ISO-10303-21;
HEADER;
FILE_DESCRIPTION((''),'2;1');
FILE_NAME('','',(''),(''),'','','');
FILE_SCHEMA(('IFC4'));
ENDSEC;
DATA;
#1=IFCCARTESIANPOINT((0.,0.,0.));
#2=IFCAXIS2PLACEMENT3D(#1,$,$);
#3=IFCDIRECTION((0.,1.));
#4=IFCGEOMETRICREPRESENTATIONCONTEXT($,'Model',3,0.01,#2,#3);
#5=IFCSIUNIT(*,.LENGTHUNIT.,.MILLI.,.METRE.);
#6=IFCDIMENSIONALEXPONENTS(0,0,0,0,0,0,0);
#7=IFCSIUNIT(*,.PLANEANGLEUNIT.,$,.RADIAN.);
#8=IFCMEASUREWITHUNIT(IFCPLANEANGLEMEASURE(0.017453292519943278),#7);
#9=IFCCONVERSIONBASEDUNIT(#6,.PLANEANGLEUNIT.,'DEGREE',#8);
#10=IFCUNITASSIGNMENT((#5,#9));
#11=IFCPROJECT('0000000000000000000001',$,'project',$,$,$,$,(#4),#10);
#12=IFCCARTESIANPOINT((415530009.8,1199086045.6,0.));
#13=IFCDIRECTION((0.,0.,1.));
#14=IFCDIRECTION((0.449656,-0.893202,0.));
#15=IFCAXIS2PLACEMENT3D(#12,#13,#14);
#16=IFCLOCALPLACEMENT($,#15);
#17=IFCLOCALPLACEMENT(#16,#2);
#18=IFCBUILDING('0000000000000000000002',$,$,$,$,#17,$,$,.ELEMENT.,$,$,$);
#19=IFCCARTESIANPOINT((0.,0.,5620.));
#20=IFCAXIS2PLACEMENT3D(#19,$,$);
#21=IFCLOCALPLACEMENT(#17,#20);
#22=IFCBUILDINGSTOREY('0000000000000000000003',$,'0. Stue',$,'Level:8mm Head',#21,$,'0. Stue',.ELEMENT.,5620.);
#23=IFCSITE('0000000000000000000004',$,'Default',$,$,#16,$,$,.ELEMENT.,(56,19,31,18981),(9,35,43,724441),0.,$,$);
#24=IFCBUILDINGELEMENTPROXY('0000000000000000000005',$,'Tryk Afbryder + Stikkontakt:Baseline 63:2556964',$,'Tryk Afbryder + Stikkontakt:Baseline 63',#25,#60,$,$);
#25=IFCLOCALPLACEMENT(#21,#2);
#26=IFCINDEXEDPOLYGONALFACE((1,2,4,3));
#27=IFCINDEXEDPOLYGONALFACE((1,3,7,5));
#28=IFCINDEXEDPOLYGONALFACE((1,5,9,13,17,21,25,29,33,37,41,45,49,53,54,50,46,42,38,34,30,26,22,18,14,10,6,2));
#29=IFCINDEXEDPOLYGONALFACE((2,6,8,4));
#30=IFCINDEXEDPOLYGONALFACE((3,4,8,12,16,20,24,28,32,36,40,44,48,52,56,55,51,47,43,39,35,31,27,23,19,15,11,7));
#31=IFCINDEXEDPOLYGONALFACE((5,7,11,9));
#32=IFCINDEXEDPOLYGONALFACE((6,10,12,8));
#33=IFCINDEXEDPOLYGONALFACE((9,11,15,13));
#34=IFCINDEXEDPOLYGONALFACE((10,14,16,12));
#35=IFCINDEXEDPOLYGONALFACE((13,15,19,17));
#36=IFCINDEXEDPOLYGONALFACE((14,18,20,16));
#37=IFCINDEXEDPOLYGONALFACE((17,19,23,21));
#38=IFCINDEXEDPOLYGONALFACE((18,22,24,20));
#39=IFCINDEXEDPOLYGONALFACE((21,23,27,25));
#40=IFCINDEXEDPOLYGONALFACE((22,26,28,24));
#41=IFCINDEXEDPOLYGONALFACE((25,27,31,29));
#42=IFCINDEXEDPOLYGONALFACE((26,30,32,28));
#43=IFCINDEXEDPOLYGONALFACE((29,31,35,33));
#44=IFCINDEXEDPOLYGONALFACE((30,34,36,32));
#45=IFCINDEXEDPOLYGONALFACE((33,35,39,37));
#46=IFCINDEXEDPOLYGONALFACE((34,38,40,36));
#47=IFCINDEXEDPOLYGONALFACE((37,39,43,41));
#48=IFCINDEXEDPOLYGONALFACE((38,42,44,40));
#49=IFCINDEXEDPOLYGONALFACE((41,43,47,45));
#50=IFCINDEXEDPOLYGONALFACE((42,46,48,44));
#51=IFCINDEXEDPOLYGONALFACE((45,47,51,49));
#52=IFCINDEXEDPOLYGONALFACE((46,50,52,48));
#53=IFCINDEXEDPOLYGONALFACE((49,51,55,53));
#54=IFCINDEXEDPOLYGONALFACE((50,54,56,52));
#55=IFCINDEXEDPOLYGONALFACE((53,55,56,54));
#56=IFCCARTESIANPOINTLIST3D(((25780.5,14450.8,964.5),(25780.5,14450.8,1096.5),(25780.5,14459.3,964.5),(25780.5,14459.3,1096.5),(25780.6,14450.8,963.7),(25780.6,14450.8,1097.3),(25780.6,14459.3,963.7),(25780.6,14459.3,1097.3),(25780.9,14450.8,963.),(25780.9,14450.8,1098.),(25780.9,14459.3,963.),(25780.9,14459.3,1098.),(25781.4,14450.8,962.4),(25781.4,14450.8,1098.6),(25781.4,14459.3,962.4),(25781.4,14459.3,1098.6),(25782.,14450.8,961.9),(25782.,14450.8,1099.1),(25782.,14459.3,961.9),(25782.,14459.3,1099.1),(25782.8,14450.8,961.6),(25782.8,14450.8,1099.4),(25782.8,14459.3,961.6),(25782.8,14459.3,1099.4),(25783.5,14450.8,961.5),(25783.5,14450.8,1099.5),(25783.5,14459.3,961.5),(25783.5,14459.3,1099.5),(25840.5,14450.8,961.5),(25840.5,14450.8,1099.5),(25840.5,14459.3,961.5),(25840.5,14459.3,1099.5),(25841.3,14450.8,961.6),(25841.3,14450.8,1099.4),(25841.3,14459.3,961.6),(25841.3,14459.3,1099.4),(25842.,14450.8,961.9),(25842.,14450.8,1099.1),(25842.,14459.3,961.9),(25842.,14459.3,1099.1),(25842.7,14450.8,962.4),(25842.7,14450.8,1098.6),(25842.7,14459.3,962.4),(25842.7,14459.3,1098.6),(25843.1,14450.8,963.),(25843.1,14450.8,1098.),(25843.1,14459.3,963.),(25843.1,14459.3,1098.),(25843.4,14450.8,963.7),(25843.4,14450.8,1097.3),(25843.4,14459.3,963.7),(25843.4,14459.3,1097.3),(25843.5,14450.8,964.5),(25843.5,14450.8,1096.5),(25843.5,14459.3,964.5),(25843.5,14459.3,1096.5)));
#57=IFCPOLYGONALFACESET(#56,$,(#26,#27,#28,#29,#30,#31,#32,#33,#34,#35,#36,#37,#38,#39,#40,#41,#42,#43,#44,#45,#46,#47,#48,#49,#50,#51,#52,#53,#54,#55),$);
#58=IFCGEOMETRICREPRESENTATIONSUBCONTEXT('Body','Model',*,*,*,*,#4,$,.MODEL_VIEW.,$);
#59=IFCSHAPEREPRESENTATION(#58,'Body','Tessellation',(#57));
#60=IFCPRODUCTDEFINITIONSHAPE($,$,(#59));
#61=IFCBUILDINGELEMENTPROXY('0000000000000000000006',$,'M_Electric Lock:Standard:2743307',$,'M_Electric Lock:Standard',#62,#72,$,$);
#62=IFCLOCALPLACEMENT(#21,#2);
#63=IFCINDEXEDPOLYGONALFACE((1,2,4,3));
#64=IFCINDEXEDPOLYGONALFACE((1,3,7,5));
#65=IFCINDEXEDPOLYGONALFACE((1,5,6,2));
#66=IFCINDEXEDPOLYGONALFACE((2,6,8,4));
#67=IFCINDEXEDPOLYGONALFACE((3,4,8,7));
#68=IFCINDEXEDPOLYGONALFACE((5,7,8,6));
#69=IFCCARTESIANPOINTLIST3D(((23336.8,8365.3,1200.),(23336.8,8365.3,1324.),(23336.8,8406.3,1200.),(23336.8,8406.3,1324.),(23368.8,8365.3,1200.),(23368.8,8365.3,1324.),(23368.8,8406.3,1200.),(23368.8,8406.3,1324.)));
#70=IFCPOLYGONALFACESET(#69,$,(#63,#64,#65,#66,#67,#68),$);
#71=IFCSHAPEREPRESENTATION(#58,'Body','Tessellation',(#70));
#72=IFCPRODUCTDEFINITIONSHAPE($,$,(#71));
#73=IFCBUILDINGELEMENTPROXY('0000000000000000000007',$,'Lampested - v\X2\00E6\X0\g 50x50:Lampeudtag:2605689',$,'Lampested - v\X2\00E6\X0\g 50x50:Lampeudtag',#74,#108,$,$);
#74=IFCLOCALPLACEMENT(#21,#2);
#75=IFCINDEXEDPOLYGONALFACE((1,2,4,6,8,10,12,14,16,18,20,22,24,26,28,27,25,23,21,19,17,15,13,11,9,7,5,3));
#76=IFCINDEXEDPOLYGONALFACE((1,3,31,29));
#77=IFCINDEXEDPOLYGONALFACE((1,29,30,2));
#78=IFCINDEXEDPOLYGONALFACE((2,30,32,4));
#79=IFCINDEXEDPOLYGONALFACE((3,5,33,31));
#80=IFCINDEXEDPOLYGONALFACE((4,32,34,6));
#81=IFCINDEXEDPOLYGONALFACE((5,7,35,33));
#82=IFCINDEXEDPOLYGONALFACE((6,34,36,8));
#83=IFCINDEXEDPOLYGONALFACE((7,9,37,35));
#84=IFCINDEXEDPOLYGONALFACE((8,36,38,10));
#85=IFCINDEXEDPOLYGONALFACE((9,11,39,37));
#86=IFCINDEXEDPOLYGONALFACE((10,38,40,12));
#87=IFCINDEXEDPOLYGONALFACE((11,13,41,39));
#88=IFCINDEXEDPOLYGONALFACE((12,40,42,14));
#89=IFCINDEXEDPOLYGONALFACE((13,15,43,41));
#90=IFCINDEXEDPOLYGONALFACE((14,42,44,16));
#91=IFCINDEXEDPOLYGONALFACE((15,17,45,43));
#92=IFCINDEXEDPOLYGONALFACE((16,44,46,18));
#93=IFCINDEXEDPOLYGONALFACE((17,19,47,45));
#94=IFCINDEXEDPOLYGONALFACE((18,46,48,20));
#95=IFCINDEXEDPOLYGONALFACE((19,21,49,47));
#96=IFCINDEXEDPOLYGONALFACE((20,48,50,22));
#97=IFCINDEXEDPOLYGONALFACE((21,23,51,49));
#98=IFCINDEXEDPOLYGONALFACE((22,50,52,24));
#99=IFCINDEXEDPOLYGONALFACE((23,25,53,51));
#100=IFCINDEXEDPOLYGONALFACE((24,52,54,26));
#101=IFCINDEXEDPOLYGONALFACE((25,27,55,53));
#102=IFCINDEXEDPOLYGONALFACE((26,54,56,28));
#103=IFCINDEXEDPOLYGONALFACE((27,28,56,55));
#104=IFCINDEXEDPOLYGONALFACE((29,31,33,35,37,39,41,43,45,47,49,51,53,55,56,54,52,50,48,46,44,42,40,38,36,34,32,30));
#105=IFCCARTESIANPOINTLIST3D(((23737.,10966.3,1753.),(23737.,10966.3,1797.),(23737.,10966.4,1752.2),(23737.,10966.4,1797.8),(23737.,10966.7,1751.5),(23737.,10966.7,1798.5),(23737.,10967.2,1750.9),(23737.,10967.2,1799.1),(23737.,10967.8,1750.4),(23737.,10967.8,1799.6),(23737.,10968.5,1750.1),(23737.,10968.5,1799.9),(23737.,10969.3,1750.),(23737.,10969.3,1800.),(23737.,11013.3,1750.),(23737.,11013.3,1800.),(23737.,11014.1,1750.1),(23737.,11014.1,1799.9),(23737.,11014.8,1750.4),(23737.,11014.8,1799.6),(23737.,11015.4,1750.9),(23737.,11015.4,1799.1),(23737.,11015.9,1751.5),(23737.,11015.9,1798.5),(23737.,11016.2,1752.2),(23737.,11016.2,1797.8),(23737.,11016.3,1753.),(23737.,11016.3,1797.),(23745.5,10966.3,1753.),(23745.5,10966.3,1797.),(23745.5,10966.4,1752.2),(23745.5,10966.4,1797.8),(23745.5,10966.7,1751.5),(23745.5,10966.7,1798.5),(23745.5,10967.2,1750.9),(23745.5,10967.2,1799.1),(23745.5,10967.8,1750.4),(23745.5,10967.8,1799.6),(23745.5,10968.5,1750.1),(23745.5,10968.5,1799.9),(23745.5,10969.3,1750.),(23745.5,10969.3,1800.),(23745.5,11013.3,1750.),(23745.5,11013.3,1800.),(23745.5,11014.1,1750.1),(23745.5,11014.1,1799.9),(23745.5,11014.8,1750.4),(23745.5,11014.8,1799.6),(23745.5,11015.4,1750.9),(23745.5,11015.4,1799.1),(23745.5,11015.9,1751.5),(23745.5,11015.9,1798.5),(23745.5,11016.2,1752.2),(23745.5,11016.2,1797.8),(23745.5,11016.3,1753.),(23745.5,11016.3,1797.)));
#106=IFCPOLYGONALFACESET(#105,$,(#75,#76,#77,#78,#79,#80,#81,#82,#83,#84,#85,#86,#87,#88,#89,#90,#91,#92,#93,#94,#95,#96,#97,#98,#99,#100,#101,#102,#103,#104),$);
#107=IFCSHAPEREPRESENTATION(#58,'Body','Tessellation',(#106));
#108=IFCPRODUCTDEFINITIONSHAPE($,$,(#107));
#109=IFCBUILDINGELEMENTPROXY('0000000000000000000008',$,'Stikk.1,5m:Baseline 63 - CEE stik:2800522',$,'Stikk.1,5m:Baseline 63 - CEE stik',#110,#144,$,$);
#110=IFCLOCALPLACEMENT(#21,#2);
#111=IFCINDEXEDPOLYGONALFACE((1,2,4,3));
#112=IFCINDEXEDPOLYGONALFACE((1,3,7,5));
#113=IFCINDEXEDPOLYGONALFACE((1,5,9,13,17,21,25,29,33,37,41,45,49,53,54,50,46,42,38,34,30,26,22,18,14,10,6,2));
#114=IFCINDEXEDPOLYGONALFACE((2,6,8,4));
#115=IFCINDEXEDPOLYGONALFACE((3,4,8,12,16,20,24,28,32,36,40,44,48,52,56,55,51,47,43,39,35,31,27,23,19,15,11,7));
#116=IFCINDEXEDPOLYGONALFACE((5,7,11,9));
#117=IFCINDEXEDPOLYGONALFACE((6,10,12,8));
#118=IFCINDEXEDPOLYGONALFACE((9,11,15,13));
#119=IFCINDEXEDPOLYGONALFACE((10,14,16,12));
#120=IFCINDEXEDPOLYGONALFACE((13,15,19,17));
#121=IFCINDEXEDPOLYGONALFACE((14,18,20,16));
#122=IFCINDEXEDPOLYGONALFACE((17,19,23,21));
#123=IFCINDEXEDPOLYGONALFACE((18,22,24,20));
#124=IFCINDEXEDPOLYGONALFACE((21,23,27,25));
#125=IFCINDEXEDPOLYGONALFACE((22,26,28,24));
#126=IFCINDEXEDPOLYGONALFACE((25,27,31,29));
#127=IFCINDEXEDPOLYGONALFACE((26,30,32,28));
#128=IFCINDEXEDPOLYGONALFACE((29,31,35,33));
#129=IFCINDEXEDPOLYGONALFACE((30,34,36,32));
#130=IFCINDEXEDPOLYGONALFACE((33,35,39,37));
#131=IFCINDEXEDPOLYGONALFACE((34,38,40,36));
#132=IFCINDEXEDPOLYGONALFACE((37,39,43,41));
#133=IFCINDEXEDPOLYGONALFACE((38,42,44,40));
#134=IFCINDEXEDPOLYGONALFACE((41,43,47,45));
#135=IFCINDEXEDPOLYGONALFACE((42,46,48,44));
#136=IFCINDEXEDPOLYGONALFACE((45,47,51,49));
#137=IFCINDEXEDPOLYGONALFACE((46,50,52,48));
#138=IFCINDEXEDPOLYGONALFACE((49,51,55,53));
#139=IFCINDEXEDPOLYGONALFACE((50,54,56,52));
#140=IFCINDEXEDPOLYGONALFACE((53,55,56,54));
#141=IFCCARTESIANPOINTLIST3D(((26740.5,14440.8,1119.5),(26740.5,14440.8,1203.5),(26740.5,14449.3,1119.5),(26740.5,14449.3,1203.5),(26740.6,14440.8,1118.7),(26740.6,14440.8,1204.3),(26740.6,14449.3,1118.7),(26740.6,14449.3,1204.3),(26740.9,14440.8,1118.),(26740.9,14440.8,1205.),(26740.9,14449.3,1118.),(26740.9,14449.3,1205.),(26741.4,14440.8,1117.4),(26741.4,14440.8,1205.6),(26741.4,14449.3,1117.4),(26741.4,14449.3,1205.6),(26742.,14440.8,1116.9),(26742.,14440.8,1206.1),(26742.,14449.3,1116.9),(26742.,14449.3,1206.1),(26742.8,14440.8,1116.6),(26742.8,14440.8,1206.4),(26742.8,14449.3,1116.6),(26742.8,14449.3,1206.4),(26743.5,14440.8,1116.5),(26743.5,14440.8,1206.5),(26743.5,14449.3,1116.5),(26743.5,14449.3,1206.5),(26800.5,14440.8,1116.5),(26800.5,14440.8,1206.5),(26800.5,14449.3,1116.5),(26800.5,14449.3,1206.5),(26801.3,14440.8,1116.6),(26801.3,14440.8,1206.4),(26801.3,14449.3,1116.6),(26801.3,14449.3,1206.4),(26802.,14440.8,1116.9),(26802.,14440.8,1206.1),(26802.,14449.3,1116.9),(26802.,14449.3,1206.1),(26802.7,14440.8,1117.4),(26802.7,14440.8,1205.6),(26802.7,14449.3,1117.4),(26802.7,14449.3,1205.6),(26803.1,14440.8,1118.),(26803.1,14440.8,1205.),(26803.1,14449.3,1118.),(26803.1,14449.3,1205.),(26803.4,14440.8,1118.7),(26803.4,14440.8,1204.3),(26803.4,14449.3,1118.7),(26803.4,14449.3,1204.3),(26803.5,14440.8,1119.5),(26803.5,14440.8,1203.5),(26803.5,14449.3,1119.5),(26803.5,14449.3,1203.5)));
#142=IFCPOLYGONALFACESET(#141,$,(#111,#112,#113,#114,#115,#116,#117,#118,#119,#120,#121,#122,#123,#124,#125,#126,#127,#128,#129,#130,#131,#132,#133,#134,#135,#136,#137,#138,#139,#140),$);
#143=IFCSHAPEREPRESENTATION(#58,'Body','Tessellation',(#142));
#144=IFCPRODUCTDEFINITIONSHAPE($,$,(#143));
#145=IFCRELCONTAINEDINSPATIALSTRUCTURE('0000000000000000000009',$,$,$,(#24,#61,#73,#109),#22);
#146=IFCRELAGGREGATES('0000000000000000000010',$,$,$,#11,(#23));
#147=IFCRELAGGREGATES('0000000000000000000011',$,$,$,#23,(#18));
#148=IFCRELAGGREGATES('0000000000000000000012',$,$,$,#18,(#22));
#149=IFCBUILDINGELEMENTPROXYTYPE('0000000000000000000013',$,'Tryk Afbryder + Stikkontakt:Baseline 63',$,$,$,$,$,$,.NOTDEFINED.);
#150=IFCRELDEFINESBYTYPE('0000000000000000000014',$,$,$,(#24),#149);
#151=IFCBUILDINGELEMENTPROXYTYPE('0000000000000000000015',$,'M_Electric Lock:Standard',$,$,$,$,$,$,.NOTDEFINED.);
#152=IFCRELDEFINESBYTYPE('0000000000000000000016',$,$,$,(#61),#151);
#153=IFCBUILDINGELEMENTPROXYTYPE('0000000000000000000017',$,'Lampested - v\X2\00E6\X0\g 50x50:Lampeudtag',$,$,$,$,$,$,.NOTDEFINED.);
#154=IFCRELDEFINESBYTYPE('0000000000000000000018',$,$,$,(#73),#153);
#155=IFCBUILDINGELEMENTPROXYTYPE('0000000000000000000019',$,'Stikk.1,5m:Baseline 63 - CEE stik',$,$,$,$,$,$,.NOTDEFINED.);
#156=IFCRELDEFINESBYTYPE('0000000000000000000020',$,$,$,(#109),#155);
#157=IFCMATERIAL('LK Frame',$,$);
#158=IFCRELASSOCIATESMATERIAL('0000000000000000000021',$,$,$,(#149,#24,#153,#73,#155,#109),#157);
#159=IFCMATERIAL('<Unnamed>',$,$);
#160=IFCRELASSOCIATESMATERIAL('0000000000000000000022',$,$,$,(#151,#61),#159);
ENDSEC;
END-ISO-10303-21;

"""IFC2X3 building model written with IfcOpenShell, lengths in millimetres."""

from ifc_helpers import new_model, entity, si_unit, converted_unit, direction, frame, frame_2d, origin, origin_2d_with_axis, place, context, subcontext, project, spatial, polyline, circle_curve, parameter, trimmed, segment, composite_curve, rectangle, outline, extrude, source, transform, mapped, material, type_object, type_shapes, element, save


model = new_model("IFC2X3")

# Units and contexts
model_context = context("Model", 3, precision=0.01, world=origin(), true_north=direction((0.0, 1.0)))
body_context = subcontext(model_context, "Body", "Model", "MODEL_VIEW")
ifc_project = project(units=[si_unit("LENGTHUNIT", "METRE", prefix="MILLI"), converted_unit("PLANEANGLEUNIT", "DEGREE", entity("IfcPlaneAngleMeasure", 0.017453292519943278), si_unit("PLANEANGLEUNIT", "RADIAN"), dimensions=[0, 0, 0, 0, 0, 0, 0])], contexts=[model_context])

# Site, building, storey
site_placement = place(None, frame((415530009.8, 1199086045.6, 0.0), z_axis=(0.0, 0.0, 1.0), x_axis=(0.449656, -0.893202, 0.0)))
site = spatial("IfcSite", under=ifc_project, at=site_placement, Name="Default", CompositionType="ELEMENT", RefLatitude=(56, 19, 31, 18981), RefLongitude=(9, 35, 43, 724441), RefElevation=0.0)
building_placement = place(site_placement, origin())
building = spatial("IfcBuilding", under=site, at=building_placement, CompositionType="ELEMENT")
storey_placement = place(building_placement, frame((0.0, 0.0, 5620.0)))
storey = spatial("IfcBuildingStorey", under=building, at=storey_placement, Name="0. Stue", ObjectType="Level:8mm Head", LongName="0. Stue", CompositionType="ELEMENT", Elevation=5620.0)

# Building element proxies
ifc_material_1 = material(Name="LK Frame")
building_element_proxy_type_1 = type_object("IfcBuildingElementProxyType", Name="Tryk Afbryder + Stikkontakt:Baseline 63", PredefinedType="NOTDEFINED", material=ifc_material_1)
shared_shape_1 = source(origin(), body_context, "Body", "SweptSolid", [
    extrude(outline(composite_curve([segment(polyline([(-66.0, -31.5), (66.0, -31.5)]), True, "CONTINUOUS"), segment(trimmed(circle_curve(frame_2d((66.0, -28.5), x_axis=(-1.0, 0.0)), 3.0), [parameter(90.0)], [parameter(180.0)], True, "PARAMETER"), True, "CONTINUOUS"), segment(polyline([(69.0, -28.5), (69.0, 28.5)]), True, "CONTINUOUS"), segment(trimmed(circle_curve(frame_2d((66.0, 28.5), x_axis=(-1.0, 0.0)), 3.0), [parameter(180.0)], [parameter(270.0)], True, "PARAMETER"), True, "CONTINUOUS"), segment(polyline([(66.0, 31.5), (-66.0, 31.5)]), True, "CONTINUOUS"), segment(trimmed(circle_curve(frame_2d((-66.0, 28.5), x_axis=(1.0, 0.0)), 3.0), [parameter(90.0)], [parameter(180.0)], True, "PARAMETER"), True, "CONTINUOUS"), segment(polyline([(-69.0, 28.5), (-69.0, -28.5)]), True, "CONTINUOUS"), segment(trimmed(circle_curve(frame_2d((-66.0, -28.5), x_axis=(1.0, 0.0)), 3.0), [parameter(180.0)], [parameter(270.0)], True, "PARAMETER"), True, "CONTINUOUS")], self_intersect=False)), frame((0.0, -69.5, 0.0), z_axis=(0.0, 0.0, 1.0), x_axis=(0.0, 1.0, 0.0)), (0.0, 0.0, 1.0), 8.5),
])
type_shapes(building_element_proxy_type_1, [shared_shape_1])
proxy_1_placement = place(storey_placement, frame((25812.0, 14450.8, 1100.0), z_axis=(0.0, 1.0, 0.0), x_axis=(-1.0, 0.0, 0.0)))
element("IfcBuildingElementProxy", 1, at=proxy_1_placement, inside=storey, type_object=building_element_proxy_type_1, material=ifc_material_1, Name="Tryk Afbryder + Stikkontakt:Baseline 63:2556964", ObjectType="Tryk Afbryder + Stikkontakt:Baseline 63", context=body_context, shape_type="MappedRepresentation", body=[
    mapped(shared_shape_1, transform((0.0, 0.0, 0.0), scale=1.0)),
])
ifc_material_2 = material(Name="<Unnamed>")
building_element_proxy_type_2 = type_object("IfcBuildingElementProxyType", Name="M_Electric Lock:Standard", PredefinedType="NOTDEFINED", material=ifc_material_2)
shared_shape_2 = source(origin(), body_context, "Body", "SweptSolid", [
    extrude(rectangle(XDim=32.0, YDim=124.0, at=origin_2d_with_axis()), frame((0.0, -62.0, 0.0), z_axis=(0.0, 0.0, 1.0), x_axis=(-1.0, 0.0, 0.0)), (0.0, 0.0, 1.0), 41.0),
])
type_shapes(building_element_proxy_type_2, [shared_shape_2])
proxy_2_placement = place(storey_placement, frame((23352.8, 8406.3, 1200.0), z_axis=(0.0, -1.0, 0.0), x_axis=(-1.0, 0.0, 0.0)))
element("IfcBuildingElementProxy", 2, at=proxy_2_placement, inside=storey, type_object=building_element_proxy_type_2, material=ifc_material_2, Name="M_Electric Lock:Standard:2743307", ObjectType="M_Electric Lock:Standard", context=body_context, shape_type="MappedRepresentation", body=[
    mapped(shared_shape_2, transform((0.0, 0.0, 0.0), scale=1.0)),
])
building_element_proxy_type_3 = type_object("IfcBuildingElementProxyType", Name="Lampested - væg 50x50:Lampeudtag", PredefinedType="NOTDEFINED", material=ifc_material_1)
shared_shape_3 = source(origin(), body_context, "Body", "SweptSolid", [
    extrude(outline(composite_curve([segment(polyline([(-22.0, -25.0), (22.0, -25.0)]), True, "CONTINUOUS"), segment(trimmed(circle_curve(frame_2d((22.0, -22.0), x_axis=(-1.0, 0.0)), 3.0), [parameter(90.0)], [parameter(180.0)], True, "PARAMETER"), True, "CONTINUOUS"), segment(polyline([(25.0, -22.0), (25.0, 22.0)]), True, "CONTINUOUS"), segment(trimmed(circle_curve(frame_2d((22.0, 22.0), x_axis=(-1.0, 0.0)), 3.0), [parameter(180.0)], [parameter(270.0)], True, "PARAMETER"), True, "CONTINUOUS"), segment(polyline([(22.0, 25.0), (-22.0, 25.0)]), True, "CONTINUOUS"), segment(trimmed(circle_curve(frame_2d((-22.0, 22.0), x_axis=(1.0, 0.0)), 3.0), [parameter(90.0)], [parameter(180.0)], True, "PARAMETER"), True, "CONTINUOUS"), segment(polyline([(-25.0, 22.0), (-25.0, -22.0)]), True, "CONTINUOUS"), segment(trimmed(circle_curve(frame_2d((-22.0, -22.0), x_axis=(1.0, 0.0)), 3.0), [parameter(180.0)], [parameter(270.0)], True, "PARAMETER"), True, "CONTINUOUS")], self_intersect=False)), frame((0.0, -25.0, 0.0), z_axis=(0.0, 0.0, 1.0), x_axis=(0.0, 1.0, 0.0)), (0.0, 0.0, 1.0), 8.5),
])
type_shapes(building_element_proxy_type_3, [shared_shape_3])
proxy_3_placement = place(storey_placement, frame((23737.0, 10991.3, 1800.0), z_axis=(1.0, 0.0, 0.0), x_axis=(0.0, 1.0, 0.0)))
element("IfcBuildingElementProxy", 3, at=proxy_3_placement, inside=storey, type_object=building_element_proxy_type_3, material=ifc_material_1, Name="Lampested - væg 50x50:Lampeudtag:2605689", ObjectType="Lampested - væg 50x50:Lampeudtag", context=body_context, shape_type="MappedRepresentation", body=[
    mapped(shared_shape_3, transform((0.0, 0.0, 0.0), scale=1.0)),
])
building_element_proxy_type_4 = type_object("IfcBuildingElementProxyType", Name="Stikk.1,5m:Baseline 63 - CEE stik", PredefinedType="NOTDEFINED", material=ifc_material_1)
shared_shape_4 = source(origin(), body_context, "Body", "SweptSolid", [
    extrude(outline(composite_curve([segment(polyline([(-42.0, -31.5), (42.0, -31.5)]), True, "CONTINUOUS"), segment(trimmed(circle_curve(frame_2d((42.0, -28.5), x_axis=(-1.0, 0.0)), 3.0), [parameter(90.0)], [parameter(180.0)], True, "PARAMETER"), True, "CONTINUOUS"), segment(polyline([(45.0, -28.5), (45.0, 28.5)]), True, "CONTINUOUS"), segment(trimmed(circle_curve(frame_2d((42.0, 28.5), x_axis=(-1.0, 0.0)), 3.0), [parameter(180.0)], [parameter(270.0)], True, "PARAMETER"), True, "CONTINUOUS"), segment(polyline([(42.0, 31.5), (-42.0, 31.5)]), True, "CONTINUOUS"), segment(trimmed(circle_curve(frame_2d((-42.0, 28.5), x_axis=(1.0, 0.0)), 3.0), [parameter(90.0)], [parameter(180.0)], True, "PARAMETER"), True, "CONTINUOUS"), segment(polyline([(-45.0, 28.5), (-45.0, -28.5)]), True, "CONTINUOUS"), segment(trimmed(circle_curve(frame_2d((-42.0, -28.5), x_axis=(1.0, 0.0)), 3.0), [parameter(180.0)], [parameter(270.0)], True, "PARAMETER"), True, "CONTINUOUS")], self_intersect=False)), frame((0.0, -38.5, 0.0), z_axis=(0.0, 0.0, 1.0), x_axis=(0.0, 1.0, 0.0)), (0.0, 0.0, 1.0), 8.5),
])
type_shapes(building_element_proxy_type_4, [shared_shape_4])
proxy_4_placement = place(storey_placement, frame((26772.0, 14440.8, 1200.0), z_axis=(0.0, 1.0, 0.0), x_axis=(-1.0, 0.0, 0.0)))
element("IfcBuildingElementProxy", 4, at=proxy_4_placement, inside=storey, type_object=building_element_proxy_type_4, material=ifc_material_1, Name="Stikk.1,5m:Baseline 63 - CEE stik:2800522", ObjectType="Stikk.1,5m:Baseline 63 - CEE stik", context=body_context, shape_type="MappedRepresentation", body=[
    mapped(shared_shape_4, transform((0.0, 0.0, 0.0), scale=1.0)),
])

save(model, "model.ifc")
